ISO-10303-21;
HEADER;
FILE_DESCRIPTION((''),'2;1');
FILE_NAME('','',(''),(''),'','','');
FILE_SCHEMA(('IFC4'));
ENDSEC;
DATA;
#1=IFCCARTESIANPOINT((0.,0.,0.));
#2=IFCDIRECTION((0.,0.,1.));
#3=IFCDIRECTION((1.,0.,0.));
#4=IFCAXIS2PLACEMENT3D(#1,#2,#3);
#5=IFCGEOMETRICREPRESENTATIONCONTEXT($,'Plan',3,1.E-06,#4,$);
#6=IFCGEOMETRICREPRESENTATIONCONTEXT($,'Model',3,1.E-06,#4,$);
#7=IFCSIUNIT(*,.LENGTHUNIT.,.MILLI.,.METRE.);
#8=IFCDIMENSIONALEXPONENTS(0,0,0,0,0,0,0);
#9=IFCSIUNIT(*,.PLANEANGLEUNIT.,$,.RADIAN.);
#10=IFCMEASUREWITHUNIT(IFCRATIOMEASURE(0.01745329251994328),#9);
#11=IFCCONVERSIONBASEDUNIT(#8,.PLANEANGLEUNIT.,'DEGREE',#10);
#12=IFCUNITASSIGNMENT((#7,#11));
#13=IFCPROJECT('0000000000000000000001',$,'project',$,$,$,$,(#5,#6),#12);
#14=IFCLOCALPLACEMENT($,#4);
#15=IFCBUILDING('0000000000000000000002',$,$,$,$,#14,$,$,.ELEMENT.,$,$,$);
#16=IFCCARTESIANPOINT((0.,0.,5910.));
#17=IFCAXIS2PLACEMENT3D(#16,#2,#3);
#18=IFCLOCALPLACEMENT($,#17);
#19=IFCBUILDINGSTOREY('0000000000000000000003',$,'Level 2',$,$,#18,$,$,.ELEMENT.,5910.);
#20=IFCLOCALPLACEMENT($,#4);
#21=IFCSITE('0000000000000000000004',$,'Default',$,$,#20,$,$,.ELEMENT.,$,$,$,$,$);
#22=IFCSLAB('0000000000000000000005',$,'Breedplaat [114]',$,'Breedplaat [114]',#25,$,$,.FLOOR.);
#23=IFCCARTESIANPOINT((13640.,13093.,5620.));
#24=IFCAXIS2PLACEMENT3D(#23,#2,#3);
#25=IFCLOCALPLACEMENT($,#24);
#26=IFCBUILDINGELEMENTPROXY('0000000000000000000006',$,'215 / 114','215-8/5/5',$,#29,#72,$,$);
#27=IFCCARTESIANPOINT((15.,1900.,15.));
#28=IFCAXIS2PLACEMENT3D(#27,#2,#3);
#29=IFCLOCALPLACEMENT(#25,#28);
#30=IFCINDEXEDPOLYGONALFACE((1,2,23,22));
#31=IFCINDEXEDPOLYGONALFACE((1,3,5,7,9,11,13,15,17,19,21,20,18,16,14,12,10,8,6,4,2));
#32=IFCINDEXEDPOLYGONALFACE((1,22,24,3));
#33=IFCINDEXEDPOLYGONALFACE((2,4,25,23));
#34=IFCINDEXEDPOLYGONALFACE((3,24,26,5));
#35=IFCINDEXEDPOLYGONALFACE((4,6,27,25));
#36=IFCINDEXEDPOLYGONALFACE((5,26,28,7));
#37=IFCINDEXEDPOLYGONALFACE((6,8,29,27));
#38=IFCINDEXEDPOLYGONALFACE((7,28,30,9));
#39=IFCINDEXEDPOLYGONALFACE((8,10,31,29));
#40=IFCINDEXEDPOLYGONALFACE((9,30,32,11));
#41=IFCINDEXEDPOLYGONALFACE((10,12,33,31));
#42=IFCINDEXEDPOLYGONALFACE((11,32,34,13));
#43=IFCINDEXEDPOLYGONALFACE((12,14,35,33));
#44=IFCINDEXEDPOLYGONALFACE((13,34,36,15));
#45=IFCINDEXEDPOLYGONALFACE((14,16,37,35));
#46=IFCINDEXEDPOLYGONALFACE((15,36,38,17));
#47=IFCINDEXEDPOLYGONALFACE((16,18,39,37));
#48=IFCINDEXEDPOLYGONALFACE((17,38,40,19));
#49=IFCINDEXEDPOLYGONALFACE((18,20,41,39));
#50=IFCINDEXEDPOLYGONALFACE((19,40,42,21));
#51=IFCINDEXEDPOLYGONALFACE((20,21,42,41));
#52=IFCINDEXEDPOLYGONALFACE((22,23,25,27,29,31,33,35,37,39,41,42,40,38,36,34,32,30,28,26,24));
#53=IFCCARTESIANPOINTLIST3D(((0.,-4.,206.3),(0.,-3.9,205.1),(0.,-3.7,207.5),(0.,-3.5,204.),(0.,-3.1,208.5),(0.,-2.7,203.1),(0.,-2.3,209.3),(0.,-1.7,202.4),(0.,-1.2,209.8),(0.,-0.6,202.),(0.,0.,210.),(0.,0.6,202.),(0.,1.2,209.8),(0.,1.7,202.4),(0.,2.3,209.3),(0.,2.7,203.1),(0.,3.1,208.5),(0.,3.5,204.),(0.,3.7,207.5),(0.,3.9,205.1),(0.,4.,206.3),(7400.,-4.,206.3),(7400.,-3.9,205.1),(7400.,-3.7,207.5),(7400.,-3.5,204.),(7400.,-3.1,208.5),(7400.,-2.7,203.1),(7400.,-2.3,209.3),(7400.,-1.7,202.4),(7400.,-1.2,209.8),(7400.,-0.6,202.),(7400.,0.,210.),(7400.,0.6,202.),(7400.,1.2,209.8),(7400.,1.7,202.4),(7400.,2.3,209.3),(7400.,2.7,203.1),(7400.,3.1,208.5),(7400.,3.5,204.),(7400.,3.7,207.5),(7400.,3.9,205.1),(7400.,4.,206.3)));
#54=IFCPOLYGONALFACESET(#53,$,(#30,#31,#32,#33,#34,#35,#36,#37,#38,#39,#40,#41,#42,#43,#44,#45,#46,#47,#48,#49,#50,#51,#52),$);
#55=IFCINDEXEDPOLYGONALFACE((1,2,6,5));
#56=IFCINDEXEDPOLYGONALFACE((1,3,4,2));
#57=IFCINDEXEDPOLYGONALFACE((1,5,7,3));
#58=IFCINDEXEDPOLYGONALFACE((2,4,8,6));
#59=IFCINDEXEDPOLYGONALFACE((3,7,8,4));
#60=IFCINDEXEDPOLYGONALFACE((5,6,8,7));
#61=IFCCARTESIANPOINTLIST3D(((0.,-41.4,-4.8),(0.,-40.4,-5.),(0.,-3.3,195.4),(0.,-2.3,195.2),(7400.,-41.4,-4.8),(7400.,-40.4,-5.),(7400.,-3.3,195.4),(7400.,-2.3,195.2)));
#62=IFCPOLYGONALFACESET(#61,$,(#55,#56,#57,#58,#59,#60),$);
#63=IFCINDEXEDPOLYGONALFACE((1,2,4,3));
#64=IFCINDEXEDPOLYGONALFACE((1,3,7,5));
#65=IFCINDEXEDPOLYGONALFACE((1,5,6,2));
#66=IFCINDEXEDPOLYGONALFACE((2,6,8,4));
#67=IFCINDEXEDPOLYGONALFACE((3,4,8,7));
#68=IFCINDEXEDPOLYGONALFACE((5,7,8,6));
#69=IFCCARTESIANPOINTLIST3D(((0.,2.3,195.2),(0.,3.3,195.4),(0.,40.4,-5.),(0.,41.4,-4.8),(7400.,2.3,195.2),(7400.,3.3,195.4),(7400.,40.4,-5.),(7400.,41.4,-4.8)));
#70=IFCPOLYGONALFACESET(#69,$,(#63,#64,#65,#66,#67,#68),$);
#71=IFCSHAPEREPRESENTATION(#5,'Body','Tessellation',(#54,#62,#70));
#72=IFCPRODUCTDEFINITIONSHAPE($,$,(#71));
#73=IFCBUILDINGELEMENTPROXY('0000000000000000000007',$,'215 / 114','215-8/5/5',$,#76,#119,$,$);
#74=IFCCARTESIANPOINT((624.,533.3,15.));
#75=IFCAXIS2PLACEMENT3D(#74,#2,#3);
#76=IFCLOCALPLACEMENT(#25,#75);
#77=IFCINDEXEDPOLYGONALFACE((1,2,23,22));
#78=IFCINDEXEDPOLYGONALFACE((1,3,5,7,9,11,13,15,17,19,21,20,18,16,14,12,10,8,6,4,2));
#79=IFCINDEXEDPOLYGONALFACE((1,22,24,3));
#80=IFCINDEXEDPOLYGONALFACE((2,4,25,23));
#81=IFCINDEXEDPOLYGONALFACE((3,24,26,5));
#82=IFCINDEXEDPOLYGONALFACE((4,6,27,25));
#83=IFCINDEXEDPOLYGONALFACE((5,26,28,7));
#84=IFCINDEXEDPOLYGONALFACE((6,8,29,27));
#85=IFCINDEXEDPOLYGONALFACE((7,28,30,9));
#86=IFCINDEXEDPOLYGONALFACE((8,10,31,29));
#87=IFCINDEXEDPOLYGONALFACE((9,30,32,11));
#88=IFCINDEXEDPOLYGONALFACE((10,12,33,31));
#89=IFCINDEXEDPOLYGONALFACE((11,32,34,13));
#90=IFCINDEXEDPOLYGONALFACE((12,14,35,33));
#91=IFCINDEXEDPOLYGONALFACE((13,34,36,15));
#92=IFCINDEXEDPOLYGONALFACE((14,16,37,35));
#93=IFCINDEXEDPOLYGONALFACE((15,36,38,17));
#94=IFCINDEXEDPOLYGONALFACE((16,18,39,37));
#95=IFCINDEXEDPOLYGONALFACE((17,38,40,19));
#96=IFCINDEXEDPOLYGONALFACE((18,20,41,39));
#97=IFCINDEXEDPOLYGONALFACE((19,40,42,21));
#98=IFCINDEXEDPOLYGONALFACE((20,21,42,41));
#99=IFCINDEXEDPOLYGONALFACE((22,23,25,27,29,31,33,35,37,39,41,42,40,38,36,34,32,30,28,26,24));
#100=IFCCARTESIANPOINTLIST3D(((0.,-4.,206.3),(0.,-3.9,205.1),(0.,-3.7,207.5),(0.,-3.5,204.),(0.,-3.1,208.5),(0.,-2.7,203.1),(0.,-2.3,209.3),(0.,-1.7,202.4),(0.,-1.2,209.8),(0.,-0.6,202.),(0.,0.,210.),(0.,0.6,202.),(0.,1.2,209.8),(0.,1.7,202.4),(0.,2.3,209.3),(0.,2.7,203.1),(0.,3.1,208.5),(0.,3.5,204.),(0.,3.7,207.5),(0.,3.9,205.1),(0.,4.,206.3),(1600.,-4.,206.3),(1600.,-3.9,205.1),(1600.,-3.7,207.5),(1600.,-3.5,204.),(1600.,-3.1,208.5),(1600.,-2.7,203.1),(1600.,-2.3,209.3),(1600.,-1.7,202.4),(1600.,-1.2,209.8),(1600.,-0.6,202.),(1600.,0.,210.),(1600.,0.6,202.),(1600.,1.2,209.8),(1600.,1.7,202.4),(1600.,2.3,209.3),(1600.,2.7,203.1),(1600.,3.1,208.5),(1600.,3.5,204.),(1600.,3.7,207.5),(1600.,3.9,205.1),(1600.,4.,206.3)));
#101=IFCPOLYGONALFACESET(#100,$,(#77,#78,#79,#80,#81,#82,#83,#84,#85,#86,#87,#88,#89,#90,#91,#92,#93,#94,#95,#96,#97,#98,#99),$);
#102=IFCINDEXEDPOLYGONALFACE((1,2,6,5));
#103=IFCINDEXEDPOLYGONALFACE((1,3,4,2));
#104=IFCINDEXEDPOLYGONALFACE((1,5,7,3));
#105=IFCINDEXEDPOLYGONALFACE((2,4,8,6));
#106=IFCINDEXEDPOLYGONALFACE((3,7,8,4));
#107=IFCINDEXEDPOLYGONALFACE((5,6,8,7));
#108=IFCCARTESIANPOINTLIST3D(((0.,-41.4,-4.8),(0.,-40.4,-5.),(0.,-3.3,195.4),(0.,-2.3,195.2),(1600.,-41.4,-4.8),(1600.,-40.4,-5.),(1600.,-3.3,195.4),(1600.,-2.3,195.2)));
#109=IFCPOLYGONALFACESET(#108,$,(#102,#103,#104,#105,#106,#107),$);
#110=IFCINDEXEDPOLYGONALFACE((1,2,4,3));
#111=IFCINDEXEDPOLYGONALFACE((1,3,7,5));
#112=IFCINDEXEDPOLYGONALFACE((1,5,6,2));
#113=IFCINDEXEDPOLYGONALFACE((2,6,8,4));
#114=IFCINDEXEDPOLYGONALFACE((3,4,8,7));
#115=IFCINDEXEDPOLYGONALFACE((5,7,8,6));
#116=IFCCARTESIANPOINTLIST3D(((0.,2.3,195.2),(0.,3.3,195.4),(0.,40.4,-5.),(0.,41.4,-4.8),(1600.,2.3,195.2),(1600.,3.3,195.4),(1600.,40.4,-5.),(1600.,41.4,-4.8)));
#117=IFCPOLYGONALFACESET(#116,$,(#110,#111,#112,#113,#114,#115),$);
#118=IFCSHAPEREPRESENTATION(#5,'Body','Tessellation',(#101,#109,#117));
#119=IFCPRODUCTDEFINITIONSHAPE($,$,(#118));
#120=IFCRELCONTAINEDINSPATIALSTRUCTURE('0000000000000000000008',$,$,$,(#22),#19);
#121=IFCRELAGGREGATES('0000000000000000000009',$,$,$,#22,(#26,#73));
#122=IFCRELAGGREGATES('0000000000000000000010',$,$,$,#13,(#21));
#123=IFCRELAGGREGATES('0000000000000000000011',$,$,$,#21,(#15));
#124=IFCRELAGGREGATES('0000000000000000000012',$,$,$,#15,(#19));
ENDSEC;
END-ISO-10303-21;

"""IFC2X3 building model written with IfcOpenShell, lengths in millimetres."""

from ifc_helpers import new_model, entity, si_unit, converted_unit, frame, origin_with_axes, origin_2d_with_axis, place, context, project, spatial, rectangle, circle, extrude, element, aggregate, save


model = new_model("IFC2X3")

# Units and contexts
plan_context = context("Plan", 3, precision=1e-06, world=origin_with_axes())
model_context = context("Model", 3, precision=1e-06, world=origin_with_axes())
ifc_project = project(units=[si_unit("LENGTHUNIT", "METRE", prefix="MILLI"), converted_unit("PLANEANGLEUNIT", "DEGREE", entity("IfcRatioMeasure", 0.01745329251994328), si_unit("PLANEANGLEUNIT", "RADIAN"), dimensions=[0, 0, 0, 0, 0, 0, 0])], contexts=[plan_context, model_context])

# Site, building, storey
site_placement = place(None, origin_with_axes())
site = spatial("IfcSite", under=ifc_project, at=site_placement, Name="Default", CompositionType="ELEMENT")
building_placement = place(None, origin_with_axes())
building = spatial("IfcBuilding", under=site, at=building_placement, CompositionType="ELEMENT")
storey_placement = place(None, frame((0.0, 0.0, 5910.0), z_axis=(0.0, 0.0, 1.0), x_axis=(1.0, 0.0, 0.0)))
storey = spatial("IfcBuildingStorey", under=building, at=storey_placement, Name="Level 2", CompositionType="ELEMENT", Elevation=5910.0)

# Slab, building element proxies
slab_1_placement = place(None, frame((13640.0, 13093.0, 5620.0), z_axis=(0.0, 0.0, 1.0), x_axis=(1.0, 0.0, 0.0)))
slab_1 = element("IfcSlab", 1, at=slab_1_placement, inside=storey, Name="Breedplaat [114]", ObjectType="Breedplaat [114]", PredefinedType="FLOOR")
proxy_1_placement = place(slab_1_placement, frame((15.0, 1900.0, 15.0), z_axis=(0.0, 0.0, 1.0), x_axis=(1.0, 0.0, 0.0)))
proxy_1 = element("IfcBuildingElementProxy", 2, at=proxy_1_placement, Name="215 / 114", Description="215-8/5/5", context=plan_context, shape_type="SweptSolid", body=[
    extrude(circle(Radius=4.0, at=origin_2d_with_axis()), frame((0.0, 0.0, 206.0), z_axis=(1.0, 0.0, 0.0), x_axis=(0.0, 0.0, 1.0)), (0.0, 0.0, 1.0), 7400.0),
    extrude(rectangle(XDim=203.8, YDim=1.0, at=origin_2d_with_axis()), frame((0.0, -21.9, 95.2), z_axis=(1.0, 0.0, 0.0), x_axis=(0.0, 0.187112, 0.982339)), (0.0, 0.0, 1.0), 7400.0),
    extrude(rectangle(XDim=203.8, YDim=1.0, at=origin_2d_with_axis()), frame((0.0, 21.9, 95.2), z_axis=(1.0, 0.0, 0.0), x_axis=(0.0, -0.187112, 0.982339)), (0.0, 0.0, 1.0), 7400.0),
])
proxy_2_placement = place(slab_1_placement, frame((624.0, 533.3, 15.0), z_axis=(0.0, 0.0, 1.0), x_axis=(1.0, 0.0, 0.0)))
proxy_2 = element("IfcBuildingElementProxy", 3, at=proxy_2_placement, Name="215 / 114", Description="215-8/5/5", context=plan_context, shape_type="SweptSolid", body=[
    extrude(circle(Radius=4.0, at=origin_2d_with_axis()), frame((0.0, 0.0, 206.0), z_axis=(1.0, 0.0, 0.0), x_axis=(0.0, 0.0, 1.0)), (0.0, 0.0, 1.0), 1600.0),
    extrude(rectangle(XDim=203.8, YDim=1.0, at=origin_2d_with_axis()), frame((0.0, -21.9, 95.2), z_axis=(1.0, 0.0, 0.0), x_axis=(0.0, 0.187112, 0.982339)), (0.0, 0.0, 1.0), 1600.0),
    extrude(rectangle(XDim=203.8, YDim=1.0, at=origin_2d_with_axis()), frame((0.0, 21.9, 95.2), z_axis=(1.0, 0.0, 0.0), x_axis=(0.0, -0.187112, 0.982339)), (0.0, 0.0, 1.0), 1600.0),
])
aggregate(slab_1, [proxy_1, proxy_2])

save(model, "model.ifc")
